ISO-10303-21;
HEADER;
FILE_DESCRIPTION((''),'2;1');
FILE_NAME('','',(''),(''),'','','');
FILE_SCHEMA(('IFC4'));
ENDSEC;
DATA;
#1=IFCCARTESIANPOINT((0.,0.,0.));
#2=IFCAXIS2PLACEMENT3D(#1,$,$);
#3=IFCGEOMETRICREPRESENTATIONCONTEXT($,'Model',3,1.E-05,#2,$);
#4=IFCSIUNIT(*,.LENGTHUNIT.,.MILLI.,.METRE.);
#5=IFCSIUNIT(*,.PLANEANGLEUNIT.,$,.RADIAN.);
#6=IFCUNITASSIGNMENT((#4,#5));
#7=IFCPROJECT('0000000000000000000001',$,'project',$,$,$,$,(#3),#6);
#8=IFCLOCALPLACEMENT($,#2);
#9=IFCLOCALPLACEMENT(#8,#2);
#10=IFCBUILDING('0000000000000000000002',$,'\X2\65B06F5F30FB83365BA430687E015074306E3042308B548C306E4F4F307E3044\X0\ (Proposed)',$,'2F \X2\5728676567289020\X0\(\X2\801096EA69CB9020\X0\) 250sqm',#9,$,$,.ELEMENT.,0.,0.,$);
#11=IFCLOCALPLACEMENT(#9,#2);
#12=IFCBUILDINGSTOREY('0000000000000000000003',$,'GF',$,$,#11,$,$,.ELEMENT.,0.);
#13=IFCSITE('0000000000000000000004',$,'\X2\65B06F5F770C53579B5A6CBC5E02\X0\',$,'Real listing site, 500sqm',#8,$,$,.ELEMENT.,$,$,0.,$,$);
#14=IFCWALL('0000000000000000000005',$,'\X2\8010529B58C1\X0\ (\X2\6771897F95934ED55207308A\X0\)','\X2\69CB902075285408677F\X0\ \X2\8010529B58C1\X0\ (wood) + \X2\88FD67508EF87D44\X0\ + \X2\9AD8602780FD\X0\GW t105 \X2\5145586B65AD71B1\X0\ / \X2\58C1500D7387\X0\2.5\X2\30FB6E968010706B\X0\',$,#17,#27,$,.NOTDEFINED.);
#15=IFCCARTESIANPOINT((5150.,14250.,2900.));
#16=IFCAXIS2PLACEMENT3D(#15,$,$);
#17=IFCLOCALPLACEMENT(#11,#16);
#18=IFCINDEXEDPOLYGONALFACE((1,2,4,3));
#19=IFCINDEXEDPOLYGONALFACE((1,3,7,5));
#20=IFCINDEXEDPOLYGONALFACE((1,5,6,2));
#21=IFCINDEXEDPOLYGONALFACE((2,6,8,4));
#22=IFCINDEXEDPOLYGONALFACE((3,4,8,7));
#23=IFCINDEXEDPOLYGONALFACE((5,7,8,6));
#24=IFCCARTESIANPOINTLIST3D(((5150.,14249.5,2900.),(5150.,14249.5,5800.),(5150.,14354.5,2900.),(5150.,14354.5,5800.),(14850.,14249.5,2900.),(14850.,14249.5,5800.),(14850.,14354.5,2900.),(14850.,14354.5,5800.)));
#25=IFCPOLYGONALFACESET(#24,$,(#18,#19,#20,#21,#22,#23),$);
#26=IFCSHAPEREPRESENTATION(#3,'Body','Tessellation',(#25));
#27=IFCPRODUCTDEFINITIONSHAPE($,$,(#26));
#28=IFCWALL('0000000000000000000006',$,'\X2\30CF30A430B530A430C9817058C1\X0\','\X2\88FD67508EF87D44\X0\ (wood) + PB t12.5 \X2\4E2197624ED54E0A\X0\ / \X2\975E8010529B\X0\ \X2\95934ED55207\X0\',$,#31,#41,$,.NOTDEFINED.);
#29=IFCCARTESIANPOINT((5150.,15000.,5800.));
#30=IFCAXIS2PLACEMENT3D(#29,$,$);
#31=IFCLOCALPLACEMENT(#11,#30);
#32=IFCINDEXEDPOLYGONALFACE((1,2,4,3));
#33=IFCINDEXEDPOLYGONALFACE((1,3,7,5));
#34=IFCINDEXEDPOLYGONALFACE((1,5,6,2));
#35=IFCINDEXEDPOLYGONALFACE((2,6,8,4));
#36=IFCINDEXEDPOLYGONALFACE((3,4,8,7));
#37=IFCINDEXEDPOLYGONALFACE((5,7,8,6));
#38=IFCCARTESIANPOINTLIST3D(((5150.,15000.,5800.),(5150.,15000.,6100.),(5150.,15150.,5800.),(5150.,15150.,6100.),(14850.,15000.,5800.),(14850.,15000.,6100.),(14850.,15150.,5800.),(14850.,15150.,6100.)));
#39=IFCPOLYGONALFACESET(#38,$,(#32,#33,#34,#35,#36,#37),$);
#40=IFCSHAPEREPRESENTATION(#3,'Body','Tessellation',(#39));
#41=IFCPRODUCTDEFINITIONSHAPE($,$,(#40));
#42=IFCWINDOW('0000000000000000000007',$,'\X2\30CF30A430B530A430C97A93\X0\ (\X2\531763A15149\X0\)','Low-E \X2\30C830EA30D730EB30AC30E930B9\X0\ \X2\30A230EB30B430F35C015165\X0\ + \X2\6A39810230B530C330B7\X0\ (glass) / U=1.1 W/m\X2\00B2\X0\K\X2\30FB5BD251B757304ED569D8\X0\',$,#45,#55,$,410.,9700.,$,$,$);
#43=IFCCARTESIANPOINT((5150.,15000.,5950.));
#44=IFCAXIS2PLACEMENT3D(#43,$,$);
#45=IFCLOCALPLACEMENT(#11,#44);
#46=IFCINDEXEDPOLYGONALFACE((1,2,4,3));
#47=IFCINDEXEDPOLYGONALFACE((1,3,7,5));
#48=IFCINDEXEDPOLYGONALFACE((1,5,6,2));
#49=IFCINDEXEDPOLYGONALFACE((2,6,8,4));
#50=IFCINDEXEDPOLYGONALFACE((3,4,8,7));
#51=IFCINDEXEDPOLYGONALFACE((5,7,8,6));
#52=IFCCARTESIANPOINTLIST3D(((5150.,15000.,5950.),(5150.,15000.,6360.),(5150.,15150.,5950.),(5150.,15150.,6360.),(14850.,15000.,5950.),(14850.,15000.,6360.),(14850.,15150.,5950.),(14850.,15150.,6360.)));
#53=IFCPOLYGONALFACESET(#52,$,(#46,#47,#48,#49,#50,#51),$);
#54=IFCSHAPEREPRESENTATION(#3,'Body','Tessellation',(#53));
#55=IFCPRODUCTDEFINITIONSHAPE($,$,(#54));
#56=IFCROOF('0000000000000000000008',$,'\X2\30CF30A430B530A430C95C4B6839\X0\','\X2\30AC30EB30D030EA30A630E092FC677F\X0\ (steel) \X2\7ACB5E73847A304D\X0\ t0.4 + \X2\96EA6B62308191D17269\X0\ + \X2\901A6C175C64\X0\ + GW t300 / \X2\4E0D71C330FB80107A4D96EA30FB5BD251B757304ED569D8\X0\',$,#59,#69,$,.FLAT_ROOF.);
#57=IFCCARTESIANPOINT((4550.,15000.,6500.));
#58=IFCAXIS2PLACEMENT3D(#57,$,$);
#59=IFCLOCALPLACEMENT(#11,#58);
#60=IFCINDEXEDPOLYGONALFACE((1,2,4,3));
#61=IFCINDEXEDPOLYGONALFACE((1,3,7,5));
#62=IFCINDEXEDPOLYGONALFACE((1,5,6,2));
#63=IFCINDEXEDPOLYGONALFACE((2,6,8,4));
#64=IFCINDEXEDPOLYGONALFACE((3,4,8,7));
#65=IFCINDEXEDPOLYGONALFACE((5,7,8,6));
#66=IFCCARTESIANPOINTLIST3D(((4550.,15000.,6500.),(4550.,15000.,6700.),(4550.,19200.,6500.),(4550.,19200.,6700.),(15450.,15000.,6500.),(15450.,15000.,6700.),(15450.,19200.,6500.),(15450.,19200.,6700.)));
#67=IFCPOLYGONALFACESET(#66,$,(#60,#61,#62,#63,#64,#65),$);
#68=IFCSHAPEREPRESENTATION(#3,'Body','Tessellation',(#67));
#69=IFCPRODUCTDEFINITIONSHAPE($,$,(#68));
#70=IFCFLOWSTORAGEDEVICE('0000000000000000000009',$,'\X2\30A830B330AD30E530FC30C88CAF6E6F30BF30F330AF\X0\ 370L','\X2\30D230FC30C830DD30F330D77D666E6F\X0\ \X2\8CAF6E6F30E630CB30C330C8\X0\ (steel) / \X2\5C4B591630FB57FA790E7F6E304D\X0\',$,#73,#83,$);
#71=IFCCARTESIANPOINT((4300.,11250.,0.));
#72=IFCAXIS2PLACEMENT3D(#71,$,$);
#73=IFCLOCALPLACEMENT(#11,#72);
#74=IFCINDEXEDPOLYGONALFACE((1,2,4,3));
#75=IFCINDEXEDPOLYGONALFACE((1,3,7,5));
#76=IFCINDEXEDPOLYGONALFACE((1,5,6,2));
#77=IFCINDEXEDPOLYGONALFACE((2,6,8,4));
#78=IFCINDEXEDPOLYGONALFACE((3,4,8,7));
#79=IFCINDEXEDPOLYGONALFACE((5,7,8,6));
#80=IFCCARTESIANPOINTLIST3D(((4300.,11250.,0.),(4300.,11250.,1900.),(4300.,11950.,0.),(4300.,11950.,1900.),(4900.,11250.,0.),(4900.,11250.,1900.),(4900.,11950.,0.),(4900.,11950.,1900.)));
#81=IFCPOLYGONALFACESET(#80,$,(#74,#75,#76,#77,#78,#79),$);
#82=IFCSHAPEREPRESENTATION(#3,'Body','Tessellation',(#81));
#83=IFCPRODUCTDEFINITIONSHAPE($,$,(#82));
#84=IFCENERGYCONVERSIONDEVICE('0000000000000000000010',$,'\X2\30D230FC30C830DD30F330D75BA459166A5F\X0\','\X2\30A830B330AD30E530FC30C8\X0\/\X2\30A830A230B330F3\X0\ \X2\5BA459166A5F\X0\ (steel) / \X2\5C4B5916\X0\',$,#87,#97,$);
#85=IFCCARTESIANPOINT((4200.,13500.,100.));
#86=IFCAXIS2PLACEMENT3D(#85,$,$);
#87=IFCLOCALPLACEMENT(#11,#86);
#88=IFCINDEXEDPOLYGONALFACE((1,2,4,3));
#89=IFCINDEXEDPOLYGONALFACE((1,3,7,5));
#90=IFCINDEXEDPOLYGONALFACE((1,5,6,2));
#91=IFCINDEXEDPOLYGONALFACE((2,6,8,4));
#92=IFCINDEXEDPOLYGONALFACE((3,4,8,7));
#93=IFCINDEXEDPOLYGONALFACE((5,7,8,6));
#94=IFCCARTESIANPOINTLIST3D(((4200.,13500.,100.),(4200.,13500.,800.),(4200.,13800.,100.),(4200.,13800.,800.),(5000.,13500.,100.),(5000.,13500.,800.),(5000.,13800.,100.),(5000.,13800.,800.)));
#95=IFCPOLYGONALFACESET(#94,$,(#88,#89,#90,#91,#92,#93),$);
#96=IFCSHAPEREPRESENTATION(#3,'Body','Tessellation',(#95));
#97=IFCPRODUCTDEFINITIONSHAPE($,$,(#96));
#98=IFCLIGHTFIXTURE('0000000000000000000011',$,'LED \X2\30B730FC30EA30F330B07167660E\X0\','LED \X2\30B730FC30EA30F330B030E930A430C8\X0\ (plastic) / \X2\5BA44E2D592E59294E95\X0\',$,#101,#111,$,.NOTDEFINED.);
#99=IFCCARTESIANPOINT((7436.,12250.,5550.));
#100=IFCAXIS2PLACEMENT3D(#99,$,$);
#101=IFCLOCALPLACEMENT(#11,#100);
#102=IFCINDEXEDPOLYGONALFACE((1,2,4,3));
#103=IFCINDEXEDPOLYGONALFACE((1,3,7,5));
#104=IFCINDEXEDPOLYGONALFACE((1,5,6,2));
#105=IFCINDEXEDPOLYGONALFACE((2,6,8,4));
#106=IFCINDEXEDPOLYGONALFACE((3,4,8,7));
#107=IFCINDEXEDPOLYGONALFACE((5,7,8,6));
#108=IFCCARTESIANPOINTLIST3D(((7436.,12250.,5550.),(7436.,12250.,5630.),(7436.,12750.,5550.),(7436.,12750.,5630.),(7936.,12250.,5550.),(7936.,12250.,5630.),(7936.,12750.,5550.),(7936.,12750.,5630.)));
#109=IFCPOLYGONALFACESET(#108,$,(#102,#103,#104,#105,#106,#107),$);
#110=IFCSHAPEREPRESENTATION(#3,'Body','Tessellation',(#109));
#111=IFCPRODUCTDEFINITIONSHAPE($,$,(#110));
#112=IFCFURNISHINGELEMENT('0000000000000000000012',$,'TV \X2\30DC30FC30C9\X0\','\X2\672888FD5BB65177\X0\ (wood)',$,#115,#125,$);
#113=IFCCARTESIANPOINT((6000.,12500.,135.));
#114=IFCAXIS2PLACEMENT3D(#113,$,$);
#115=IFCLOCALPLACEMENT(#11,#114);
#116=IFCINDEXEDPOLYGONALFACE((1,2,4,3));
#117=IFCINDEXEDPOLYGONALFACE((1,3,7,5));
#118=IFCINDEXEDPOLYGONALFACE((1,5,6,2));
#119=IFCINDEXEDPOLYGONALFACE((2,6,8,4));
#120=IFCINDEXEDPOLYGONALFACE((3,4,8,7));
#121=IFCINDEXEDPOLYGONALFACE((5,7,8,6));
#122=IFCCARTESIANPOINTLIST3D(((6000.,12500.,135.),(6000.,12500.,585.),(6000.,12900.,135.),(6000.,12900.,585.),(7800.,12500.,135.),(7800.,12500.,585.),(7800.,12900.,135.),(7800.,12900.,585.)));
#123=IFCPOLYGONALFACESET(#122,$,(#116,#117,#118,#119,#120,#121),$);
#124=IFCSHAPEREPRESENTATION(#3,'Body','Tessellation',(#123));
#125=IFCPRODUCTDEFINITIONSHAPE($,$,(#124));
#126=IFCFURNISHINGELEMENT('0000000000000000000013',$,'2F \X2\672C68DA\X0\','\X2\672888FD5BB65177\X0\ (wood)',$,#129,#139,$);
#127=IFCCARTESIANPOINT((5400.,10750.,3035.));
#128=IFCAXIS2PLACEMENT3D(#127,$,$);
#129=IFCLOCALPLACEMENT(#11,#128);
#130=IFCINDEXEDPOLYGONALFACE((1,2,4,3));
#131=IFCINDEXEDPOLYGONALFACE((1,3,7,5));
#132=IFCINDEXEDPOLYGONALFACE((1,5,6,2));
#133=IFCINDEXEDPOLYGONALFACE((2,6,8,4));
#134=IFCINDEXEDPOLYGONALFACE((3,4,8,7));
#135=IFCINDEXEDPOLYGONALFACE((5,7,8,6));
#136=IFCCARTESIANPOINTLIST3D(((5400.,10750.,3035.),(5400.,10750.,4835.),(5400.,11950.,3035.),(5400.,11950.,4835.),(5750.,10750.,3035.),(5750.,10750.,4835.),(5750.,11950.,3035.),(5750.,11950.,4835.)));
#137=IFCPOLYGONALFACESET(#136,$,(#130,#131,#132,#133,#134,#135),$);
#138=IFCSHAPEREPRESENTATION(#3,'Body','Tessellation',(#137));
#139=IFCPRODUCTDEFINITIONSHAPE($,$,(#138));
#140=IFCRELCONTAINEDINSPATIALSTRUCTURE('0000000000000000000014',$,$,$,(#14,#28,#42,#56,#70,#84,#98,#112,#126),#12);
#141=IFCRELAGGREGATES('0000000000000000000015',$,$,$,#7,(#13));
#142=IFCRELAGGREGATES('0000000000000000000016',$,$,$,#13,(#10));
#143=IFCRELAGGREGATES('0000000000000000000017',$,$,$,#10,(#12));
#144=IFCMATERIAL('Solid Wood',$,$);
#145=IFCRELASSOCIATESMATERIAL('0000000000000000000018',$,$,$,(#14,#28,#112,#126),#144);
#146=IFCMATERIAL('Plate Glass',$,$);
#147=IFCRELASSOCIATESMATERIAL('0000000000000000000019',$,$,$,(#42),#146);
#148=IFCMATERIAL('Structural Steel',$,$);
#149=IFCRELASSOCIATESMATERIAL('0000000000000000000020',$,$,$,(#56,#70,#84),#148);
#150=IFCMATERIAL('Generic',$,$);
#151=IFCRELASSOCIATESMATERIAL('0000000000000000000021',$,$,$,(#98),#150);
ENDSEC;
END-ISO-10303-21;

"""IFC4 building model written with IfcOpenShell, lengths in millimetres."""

from ifc_helpers import new_model, si_unit, frame, frame_2d, origin, place, context, project, spatial, rectangle, extrude, material, element, fill, save


model = new_model("IFC4")

# Units and contexts
model_context = context("Model", 3, precision=1e-05, world=origin())
ifc_project = project(units=[si_unit("LENGTHUNIT", "METRE", prefix="MILLI"), si_unit("PLANEANGLEUNIT", "RADIAN")], contexts=[model_context])

# Site, building, storey
site_placement = place(None, origin())
site = spatial("IfcSite", under=ifc_project, at=site_placement, Name="新潟県南魚沼市", ObjectType="Real listing site, 500sqm", CompositionType="ELEMENT", RefElevation=0.0)
building_placement = place(site_placement, origin())
building = spatial("IfcBuilding", under=site, at=building_placement, Name="新潟・茶室と縁側のある和の住まい (Proposed)", ObjectType="2F 在来木造(耐雪構造) 250sqm", CompositionType="ELEMENT", ElevationOfRefHeight=0.0, ElevationOfTerrain=0.0)
storey_placement = place(building_placement, origin())
storey = spatial("IfcBuildingStorey", under=building, at=storey_placement, Name="GF", CompositionType="ELEMENT", Elevation=0.0)

# Shared definitions
ifc_material_1 = material(Name="Solid Wood")

# Wall
wall_1_placement = place(storey_placement, frame((5150.0, 14250.0, 2900.0)))
element("IfcWall", 1, at=wall_1_placement, inside=storey, material=ifc_material_1, Name="耐力壁 (東西間仕切り)", Description="構造用合板 耐力壁 (wood) + 製材軸組 + 高性能GW t105 充填断熱 / 壁倍率2.5・準耐火", PredefinedType="NOTDEFINED", context=model_context, shape_type="SweptSolid", body=[
    extrude(rectangle(XDim=9700.0, YDim=105.0, at=frame_2d((4850.0, 52.0))), frame((5150.0, 14250.0, 2900.0)), (0.0, 0.0, 1.0), 2900.0),
])

# Wall, opening, window
wall_2_placement = place(storey_placement, frame((5150.0, 15000.0, 5800.0)))
wall_2 = element("IfcWall", 2, at=wall_2_placement, inside=storey, material=ifc_material_1, Name="ハイサイド腰壁", Description="製材軸組 (wood) + PB t12.5 両面仕上 / 非耐力 間仕切", PredefinedType="NOTDEFINED", context=model_context, shape_type="SweptSolid", body=[
    extrude(rectangle(XDim=9700.0, YDim=150.0, at=frame_2d((4850.0, 75.0))), frame((5150.0, 15000.0, 5800.0)), (0.0, 0.0, 1.0), 700.0),
])
opening_1_placement = place(storey_placement, frame((5150.0, 15000.0, 5950.0)))
opening_1 = element("IfcOpeningElement", 3, at=opening_1_placement, cuts=wall_2, PredefinedType="NOTDEFINED", context=model_context, shape_type="SweptSolid", body=[
    extrude(rectangle(XDim=9700.0, YDim=150.0, at=frame_2d((4850.0, 75.0))), frame((5150.0, 15000.0, 5950.0)), (0.0, 0.0, 1.0), 410.0),
])
ifc_material_2 = material(Name="Plate Glass")
window_placement = place(storey_placement, frame((5150.0, 15000.0, 5950.0)))
window = element("IfcWindow", 4, at=window_placement, inside=storey, material=ifc_material_2, Name="ハイサイド窓 (北採光)", Description="Low-E トリプルガラス アルゴン封入 + 樹脂サッシ (glass) / U=1.1 W/m²K・寒冷地仕様", OverallHeight=410.0, OverallWidth=9700.0, context=model_context, shape_type="SweptSolid", body=[
    extrude(rectangle(XDim=9700.0, YDim=150.0, at=frame_2d((4850.0, 75.0))), frame((5150.0, 15000.0, 5950.0)), (0.0, 0.0, 1.0), 410.0),
])
fill(opening_1, window)

# Roof
ifc_material_3 = material(Name="Structural Steel")
roof_placement = place(storey_placement, frame((4550.0, 15000.0, 6500.0)))
element("IfcRoof", 5, at=roof_placement, inside=storey, material=ifc_material_3, Name="ハイサイド屋根", Description="ガルバリウム鋼板 (steel) 立平葺き t0.4 + 雪止め金物 + 通気層 + GW t300 / 不燃・耐積雪・寒冷地仕様", PredefinedType="FLAT_ROOF", context=model_context, shape_type="SweptSolid", body=[
    extrude(rectangle(XDim=10900.0, YDim=4200.0, at=frame_2d((5450.0, 2100.0))), frame((4550.0, 15000.0, 6500.0)), (0.0, 0.0, 1.0), 200.0),
])

# Flow storage device
flow_storage_device_placement = place(storey_placement, frame((4300.0, 11250.0, 0.0)))
element("IfcFlowStorageDevice", 6, at=flow_storage_device_placement, inside=storey, material=ifc_material_3, Name="エコキュート貯湯タンク 370L", Description="ヒートポンプ給湯 貯湯ユニット (steel) / 屋外・基礎置き", context=model_context, shape_type="SweptSolid", body=[
    extrude(rectangle(XDim=600.0, YDim=700.0, at=frame_2d((300.0, 350.0))), frame((4300.0, 11250.0, 0.0)), (0.0, 0.0, 1.0), 1900.0),
])

# Energy conversion device
energy_conversion_device_placement = place(storey_placement, frame((4200.0, 13500.0, 100.0)))
element("IfcEnergyConversionDevice", 7, at=energy_conversion_device_placement, inside=storey, material=ifc_material_3, Name="ヒートポンプ室外機", Description="エコキュート/エアコン 室外機 (steel) / 屋外", context=model_context, shape_type="SweptSolid", body=[
    extrude(rectangle(XDim=800.0, YDim=300.0, at=frame_2d((400.0, 150.0))), frame((4200.0, 13500.0, 100.0)), (0.0, 0.0, 1.0), 700.0),
])

# Light fixture
ifc_material_4 = material(Name="Generic")
light_fixture_placement = place(storey_placement, frame((7436.0, 12250.0, 5550.0)))
element("IfcLightFixture", 8, at=light_fixture_placement, inside=storey, material=ifc_material_4, Name="LED シーリング照明", Description="LED シーリングライト (plastic) / 室中央天井", PredefinedType="NOTDEFINED", context=model_context, shape_type="SweptSolid", body=[
    extrude(rectangle(XDim=500.0, YDim=500.0, at=frame_2d((250.0, 250.0))), frame((7436.0, 12250.0, 5550.0)), (0.0, 0.0, 1.0), 80.0),
])

# Furnishing elements
furnishing_1_placement = place(storey_placement, frame((6000.0, 12500.0, 135.0)))
element("IfcFurnishingElement", 9, at=furnishing_1_placement, inside=storey, material=ifc_material_1, Name="TV ボード", Description="木製家具 (wood)", context=model_context, shape_type="SweptSolid", body=[
    extrude(rectangle(XDim=1800.0, YDim=400.0, at=frame_2d((900.0, 200.0))), frame((6000.0, 12500.0, 135.0)), (0.0, 0.0, 1.0), 450.0),
])
furnishing_2_placement = place(storey_placement, frame((5400.0, 10750.0, 3035.0)))
element("IfcFurnishingElement", 10, at=furnishing_2_placement, inside=storey, material=ifc_material_1, Name="2F 本棚", Description="木製家具 (wood)", context=model_context, shape_type="SweptSolid", body=[
    extrude(rectangle(XDim=350.0, YDim=1200.0, at=frame_2d((175.0, 600.0))), frame((5400.0, 10750.0, 3035.0)), (0.0, 0.0, 1.0), 1800.0),
])

save(model, "model.ifc")
